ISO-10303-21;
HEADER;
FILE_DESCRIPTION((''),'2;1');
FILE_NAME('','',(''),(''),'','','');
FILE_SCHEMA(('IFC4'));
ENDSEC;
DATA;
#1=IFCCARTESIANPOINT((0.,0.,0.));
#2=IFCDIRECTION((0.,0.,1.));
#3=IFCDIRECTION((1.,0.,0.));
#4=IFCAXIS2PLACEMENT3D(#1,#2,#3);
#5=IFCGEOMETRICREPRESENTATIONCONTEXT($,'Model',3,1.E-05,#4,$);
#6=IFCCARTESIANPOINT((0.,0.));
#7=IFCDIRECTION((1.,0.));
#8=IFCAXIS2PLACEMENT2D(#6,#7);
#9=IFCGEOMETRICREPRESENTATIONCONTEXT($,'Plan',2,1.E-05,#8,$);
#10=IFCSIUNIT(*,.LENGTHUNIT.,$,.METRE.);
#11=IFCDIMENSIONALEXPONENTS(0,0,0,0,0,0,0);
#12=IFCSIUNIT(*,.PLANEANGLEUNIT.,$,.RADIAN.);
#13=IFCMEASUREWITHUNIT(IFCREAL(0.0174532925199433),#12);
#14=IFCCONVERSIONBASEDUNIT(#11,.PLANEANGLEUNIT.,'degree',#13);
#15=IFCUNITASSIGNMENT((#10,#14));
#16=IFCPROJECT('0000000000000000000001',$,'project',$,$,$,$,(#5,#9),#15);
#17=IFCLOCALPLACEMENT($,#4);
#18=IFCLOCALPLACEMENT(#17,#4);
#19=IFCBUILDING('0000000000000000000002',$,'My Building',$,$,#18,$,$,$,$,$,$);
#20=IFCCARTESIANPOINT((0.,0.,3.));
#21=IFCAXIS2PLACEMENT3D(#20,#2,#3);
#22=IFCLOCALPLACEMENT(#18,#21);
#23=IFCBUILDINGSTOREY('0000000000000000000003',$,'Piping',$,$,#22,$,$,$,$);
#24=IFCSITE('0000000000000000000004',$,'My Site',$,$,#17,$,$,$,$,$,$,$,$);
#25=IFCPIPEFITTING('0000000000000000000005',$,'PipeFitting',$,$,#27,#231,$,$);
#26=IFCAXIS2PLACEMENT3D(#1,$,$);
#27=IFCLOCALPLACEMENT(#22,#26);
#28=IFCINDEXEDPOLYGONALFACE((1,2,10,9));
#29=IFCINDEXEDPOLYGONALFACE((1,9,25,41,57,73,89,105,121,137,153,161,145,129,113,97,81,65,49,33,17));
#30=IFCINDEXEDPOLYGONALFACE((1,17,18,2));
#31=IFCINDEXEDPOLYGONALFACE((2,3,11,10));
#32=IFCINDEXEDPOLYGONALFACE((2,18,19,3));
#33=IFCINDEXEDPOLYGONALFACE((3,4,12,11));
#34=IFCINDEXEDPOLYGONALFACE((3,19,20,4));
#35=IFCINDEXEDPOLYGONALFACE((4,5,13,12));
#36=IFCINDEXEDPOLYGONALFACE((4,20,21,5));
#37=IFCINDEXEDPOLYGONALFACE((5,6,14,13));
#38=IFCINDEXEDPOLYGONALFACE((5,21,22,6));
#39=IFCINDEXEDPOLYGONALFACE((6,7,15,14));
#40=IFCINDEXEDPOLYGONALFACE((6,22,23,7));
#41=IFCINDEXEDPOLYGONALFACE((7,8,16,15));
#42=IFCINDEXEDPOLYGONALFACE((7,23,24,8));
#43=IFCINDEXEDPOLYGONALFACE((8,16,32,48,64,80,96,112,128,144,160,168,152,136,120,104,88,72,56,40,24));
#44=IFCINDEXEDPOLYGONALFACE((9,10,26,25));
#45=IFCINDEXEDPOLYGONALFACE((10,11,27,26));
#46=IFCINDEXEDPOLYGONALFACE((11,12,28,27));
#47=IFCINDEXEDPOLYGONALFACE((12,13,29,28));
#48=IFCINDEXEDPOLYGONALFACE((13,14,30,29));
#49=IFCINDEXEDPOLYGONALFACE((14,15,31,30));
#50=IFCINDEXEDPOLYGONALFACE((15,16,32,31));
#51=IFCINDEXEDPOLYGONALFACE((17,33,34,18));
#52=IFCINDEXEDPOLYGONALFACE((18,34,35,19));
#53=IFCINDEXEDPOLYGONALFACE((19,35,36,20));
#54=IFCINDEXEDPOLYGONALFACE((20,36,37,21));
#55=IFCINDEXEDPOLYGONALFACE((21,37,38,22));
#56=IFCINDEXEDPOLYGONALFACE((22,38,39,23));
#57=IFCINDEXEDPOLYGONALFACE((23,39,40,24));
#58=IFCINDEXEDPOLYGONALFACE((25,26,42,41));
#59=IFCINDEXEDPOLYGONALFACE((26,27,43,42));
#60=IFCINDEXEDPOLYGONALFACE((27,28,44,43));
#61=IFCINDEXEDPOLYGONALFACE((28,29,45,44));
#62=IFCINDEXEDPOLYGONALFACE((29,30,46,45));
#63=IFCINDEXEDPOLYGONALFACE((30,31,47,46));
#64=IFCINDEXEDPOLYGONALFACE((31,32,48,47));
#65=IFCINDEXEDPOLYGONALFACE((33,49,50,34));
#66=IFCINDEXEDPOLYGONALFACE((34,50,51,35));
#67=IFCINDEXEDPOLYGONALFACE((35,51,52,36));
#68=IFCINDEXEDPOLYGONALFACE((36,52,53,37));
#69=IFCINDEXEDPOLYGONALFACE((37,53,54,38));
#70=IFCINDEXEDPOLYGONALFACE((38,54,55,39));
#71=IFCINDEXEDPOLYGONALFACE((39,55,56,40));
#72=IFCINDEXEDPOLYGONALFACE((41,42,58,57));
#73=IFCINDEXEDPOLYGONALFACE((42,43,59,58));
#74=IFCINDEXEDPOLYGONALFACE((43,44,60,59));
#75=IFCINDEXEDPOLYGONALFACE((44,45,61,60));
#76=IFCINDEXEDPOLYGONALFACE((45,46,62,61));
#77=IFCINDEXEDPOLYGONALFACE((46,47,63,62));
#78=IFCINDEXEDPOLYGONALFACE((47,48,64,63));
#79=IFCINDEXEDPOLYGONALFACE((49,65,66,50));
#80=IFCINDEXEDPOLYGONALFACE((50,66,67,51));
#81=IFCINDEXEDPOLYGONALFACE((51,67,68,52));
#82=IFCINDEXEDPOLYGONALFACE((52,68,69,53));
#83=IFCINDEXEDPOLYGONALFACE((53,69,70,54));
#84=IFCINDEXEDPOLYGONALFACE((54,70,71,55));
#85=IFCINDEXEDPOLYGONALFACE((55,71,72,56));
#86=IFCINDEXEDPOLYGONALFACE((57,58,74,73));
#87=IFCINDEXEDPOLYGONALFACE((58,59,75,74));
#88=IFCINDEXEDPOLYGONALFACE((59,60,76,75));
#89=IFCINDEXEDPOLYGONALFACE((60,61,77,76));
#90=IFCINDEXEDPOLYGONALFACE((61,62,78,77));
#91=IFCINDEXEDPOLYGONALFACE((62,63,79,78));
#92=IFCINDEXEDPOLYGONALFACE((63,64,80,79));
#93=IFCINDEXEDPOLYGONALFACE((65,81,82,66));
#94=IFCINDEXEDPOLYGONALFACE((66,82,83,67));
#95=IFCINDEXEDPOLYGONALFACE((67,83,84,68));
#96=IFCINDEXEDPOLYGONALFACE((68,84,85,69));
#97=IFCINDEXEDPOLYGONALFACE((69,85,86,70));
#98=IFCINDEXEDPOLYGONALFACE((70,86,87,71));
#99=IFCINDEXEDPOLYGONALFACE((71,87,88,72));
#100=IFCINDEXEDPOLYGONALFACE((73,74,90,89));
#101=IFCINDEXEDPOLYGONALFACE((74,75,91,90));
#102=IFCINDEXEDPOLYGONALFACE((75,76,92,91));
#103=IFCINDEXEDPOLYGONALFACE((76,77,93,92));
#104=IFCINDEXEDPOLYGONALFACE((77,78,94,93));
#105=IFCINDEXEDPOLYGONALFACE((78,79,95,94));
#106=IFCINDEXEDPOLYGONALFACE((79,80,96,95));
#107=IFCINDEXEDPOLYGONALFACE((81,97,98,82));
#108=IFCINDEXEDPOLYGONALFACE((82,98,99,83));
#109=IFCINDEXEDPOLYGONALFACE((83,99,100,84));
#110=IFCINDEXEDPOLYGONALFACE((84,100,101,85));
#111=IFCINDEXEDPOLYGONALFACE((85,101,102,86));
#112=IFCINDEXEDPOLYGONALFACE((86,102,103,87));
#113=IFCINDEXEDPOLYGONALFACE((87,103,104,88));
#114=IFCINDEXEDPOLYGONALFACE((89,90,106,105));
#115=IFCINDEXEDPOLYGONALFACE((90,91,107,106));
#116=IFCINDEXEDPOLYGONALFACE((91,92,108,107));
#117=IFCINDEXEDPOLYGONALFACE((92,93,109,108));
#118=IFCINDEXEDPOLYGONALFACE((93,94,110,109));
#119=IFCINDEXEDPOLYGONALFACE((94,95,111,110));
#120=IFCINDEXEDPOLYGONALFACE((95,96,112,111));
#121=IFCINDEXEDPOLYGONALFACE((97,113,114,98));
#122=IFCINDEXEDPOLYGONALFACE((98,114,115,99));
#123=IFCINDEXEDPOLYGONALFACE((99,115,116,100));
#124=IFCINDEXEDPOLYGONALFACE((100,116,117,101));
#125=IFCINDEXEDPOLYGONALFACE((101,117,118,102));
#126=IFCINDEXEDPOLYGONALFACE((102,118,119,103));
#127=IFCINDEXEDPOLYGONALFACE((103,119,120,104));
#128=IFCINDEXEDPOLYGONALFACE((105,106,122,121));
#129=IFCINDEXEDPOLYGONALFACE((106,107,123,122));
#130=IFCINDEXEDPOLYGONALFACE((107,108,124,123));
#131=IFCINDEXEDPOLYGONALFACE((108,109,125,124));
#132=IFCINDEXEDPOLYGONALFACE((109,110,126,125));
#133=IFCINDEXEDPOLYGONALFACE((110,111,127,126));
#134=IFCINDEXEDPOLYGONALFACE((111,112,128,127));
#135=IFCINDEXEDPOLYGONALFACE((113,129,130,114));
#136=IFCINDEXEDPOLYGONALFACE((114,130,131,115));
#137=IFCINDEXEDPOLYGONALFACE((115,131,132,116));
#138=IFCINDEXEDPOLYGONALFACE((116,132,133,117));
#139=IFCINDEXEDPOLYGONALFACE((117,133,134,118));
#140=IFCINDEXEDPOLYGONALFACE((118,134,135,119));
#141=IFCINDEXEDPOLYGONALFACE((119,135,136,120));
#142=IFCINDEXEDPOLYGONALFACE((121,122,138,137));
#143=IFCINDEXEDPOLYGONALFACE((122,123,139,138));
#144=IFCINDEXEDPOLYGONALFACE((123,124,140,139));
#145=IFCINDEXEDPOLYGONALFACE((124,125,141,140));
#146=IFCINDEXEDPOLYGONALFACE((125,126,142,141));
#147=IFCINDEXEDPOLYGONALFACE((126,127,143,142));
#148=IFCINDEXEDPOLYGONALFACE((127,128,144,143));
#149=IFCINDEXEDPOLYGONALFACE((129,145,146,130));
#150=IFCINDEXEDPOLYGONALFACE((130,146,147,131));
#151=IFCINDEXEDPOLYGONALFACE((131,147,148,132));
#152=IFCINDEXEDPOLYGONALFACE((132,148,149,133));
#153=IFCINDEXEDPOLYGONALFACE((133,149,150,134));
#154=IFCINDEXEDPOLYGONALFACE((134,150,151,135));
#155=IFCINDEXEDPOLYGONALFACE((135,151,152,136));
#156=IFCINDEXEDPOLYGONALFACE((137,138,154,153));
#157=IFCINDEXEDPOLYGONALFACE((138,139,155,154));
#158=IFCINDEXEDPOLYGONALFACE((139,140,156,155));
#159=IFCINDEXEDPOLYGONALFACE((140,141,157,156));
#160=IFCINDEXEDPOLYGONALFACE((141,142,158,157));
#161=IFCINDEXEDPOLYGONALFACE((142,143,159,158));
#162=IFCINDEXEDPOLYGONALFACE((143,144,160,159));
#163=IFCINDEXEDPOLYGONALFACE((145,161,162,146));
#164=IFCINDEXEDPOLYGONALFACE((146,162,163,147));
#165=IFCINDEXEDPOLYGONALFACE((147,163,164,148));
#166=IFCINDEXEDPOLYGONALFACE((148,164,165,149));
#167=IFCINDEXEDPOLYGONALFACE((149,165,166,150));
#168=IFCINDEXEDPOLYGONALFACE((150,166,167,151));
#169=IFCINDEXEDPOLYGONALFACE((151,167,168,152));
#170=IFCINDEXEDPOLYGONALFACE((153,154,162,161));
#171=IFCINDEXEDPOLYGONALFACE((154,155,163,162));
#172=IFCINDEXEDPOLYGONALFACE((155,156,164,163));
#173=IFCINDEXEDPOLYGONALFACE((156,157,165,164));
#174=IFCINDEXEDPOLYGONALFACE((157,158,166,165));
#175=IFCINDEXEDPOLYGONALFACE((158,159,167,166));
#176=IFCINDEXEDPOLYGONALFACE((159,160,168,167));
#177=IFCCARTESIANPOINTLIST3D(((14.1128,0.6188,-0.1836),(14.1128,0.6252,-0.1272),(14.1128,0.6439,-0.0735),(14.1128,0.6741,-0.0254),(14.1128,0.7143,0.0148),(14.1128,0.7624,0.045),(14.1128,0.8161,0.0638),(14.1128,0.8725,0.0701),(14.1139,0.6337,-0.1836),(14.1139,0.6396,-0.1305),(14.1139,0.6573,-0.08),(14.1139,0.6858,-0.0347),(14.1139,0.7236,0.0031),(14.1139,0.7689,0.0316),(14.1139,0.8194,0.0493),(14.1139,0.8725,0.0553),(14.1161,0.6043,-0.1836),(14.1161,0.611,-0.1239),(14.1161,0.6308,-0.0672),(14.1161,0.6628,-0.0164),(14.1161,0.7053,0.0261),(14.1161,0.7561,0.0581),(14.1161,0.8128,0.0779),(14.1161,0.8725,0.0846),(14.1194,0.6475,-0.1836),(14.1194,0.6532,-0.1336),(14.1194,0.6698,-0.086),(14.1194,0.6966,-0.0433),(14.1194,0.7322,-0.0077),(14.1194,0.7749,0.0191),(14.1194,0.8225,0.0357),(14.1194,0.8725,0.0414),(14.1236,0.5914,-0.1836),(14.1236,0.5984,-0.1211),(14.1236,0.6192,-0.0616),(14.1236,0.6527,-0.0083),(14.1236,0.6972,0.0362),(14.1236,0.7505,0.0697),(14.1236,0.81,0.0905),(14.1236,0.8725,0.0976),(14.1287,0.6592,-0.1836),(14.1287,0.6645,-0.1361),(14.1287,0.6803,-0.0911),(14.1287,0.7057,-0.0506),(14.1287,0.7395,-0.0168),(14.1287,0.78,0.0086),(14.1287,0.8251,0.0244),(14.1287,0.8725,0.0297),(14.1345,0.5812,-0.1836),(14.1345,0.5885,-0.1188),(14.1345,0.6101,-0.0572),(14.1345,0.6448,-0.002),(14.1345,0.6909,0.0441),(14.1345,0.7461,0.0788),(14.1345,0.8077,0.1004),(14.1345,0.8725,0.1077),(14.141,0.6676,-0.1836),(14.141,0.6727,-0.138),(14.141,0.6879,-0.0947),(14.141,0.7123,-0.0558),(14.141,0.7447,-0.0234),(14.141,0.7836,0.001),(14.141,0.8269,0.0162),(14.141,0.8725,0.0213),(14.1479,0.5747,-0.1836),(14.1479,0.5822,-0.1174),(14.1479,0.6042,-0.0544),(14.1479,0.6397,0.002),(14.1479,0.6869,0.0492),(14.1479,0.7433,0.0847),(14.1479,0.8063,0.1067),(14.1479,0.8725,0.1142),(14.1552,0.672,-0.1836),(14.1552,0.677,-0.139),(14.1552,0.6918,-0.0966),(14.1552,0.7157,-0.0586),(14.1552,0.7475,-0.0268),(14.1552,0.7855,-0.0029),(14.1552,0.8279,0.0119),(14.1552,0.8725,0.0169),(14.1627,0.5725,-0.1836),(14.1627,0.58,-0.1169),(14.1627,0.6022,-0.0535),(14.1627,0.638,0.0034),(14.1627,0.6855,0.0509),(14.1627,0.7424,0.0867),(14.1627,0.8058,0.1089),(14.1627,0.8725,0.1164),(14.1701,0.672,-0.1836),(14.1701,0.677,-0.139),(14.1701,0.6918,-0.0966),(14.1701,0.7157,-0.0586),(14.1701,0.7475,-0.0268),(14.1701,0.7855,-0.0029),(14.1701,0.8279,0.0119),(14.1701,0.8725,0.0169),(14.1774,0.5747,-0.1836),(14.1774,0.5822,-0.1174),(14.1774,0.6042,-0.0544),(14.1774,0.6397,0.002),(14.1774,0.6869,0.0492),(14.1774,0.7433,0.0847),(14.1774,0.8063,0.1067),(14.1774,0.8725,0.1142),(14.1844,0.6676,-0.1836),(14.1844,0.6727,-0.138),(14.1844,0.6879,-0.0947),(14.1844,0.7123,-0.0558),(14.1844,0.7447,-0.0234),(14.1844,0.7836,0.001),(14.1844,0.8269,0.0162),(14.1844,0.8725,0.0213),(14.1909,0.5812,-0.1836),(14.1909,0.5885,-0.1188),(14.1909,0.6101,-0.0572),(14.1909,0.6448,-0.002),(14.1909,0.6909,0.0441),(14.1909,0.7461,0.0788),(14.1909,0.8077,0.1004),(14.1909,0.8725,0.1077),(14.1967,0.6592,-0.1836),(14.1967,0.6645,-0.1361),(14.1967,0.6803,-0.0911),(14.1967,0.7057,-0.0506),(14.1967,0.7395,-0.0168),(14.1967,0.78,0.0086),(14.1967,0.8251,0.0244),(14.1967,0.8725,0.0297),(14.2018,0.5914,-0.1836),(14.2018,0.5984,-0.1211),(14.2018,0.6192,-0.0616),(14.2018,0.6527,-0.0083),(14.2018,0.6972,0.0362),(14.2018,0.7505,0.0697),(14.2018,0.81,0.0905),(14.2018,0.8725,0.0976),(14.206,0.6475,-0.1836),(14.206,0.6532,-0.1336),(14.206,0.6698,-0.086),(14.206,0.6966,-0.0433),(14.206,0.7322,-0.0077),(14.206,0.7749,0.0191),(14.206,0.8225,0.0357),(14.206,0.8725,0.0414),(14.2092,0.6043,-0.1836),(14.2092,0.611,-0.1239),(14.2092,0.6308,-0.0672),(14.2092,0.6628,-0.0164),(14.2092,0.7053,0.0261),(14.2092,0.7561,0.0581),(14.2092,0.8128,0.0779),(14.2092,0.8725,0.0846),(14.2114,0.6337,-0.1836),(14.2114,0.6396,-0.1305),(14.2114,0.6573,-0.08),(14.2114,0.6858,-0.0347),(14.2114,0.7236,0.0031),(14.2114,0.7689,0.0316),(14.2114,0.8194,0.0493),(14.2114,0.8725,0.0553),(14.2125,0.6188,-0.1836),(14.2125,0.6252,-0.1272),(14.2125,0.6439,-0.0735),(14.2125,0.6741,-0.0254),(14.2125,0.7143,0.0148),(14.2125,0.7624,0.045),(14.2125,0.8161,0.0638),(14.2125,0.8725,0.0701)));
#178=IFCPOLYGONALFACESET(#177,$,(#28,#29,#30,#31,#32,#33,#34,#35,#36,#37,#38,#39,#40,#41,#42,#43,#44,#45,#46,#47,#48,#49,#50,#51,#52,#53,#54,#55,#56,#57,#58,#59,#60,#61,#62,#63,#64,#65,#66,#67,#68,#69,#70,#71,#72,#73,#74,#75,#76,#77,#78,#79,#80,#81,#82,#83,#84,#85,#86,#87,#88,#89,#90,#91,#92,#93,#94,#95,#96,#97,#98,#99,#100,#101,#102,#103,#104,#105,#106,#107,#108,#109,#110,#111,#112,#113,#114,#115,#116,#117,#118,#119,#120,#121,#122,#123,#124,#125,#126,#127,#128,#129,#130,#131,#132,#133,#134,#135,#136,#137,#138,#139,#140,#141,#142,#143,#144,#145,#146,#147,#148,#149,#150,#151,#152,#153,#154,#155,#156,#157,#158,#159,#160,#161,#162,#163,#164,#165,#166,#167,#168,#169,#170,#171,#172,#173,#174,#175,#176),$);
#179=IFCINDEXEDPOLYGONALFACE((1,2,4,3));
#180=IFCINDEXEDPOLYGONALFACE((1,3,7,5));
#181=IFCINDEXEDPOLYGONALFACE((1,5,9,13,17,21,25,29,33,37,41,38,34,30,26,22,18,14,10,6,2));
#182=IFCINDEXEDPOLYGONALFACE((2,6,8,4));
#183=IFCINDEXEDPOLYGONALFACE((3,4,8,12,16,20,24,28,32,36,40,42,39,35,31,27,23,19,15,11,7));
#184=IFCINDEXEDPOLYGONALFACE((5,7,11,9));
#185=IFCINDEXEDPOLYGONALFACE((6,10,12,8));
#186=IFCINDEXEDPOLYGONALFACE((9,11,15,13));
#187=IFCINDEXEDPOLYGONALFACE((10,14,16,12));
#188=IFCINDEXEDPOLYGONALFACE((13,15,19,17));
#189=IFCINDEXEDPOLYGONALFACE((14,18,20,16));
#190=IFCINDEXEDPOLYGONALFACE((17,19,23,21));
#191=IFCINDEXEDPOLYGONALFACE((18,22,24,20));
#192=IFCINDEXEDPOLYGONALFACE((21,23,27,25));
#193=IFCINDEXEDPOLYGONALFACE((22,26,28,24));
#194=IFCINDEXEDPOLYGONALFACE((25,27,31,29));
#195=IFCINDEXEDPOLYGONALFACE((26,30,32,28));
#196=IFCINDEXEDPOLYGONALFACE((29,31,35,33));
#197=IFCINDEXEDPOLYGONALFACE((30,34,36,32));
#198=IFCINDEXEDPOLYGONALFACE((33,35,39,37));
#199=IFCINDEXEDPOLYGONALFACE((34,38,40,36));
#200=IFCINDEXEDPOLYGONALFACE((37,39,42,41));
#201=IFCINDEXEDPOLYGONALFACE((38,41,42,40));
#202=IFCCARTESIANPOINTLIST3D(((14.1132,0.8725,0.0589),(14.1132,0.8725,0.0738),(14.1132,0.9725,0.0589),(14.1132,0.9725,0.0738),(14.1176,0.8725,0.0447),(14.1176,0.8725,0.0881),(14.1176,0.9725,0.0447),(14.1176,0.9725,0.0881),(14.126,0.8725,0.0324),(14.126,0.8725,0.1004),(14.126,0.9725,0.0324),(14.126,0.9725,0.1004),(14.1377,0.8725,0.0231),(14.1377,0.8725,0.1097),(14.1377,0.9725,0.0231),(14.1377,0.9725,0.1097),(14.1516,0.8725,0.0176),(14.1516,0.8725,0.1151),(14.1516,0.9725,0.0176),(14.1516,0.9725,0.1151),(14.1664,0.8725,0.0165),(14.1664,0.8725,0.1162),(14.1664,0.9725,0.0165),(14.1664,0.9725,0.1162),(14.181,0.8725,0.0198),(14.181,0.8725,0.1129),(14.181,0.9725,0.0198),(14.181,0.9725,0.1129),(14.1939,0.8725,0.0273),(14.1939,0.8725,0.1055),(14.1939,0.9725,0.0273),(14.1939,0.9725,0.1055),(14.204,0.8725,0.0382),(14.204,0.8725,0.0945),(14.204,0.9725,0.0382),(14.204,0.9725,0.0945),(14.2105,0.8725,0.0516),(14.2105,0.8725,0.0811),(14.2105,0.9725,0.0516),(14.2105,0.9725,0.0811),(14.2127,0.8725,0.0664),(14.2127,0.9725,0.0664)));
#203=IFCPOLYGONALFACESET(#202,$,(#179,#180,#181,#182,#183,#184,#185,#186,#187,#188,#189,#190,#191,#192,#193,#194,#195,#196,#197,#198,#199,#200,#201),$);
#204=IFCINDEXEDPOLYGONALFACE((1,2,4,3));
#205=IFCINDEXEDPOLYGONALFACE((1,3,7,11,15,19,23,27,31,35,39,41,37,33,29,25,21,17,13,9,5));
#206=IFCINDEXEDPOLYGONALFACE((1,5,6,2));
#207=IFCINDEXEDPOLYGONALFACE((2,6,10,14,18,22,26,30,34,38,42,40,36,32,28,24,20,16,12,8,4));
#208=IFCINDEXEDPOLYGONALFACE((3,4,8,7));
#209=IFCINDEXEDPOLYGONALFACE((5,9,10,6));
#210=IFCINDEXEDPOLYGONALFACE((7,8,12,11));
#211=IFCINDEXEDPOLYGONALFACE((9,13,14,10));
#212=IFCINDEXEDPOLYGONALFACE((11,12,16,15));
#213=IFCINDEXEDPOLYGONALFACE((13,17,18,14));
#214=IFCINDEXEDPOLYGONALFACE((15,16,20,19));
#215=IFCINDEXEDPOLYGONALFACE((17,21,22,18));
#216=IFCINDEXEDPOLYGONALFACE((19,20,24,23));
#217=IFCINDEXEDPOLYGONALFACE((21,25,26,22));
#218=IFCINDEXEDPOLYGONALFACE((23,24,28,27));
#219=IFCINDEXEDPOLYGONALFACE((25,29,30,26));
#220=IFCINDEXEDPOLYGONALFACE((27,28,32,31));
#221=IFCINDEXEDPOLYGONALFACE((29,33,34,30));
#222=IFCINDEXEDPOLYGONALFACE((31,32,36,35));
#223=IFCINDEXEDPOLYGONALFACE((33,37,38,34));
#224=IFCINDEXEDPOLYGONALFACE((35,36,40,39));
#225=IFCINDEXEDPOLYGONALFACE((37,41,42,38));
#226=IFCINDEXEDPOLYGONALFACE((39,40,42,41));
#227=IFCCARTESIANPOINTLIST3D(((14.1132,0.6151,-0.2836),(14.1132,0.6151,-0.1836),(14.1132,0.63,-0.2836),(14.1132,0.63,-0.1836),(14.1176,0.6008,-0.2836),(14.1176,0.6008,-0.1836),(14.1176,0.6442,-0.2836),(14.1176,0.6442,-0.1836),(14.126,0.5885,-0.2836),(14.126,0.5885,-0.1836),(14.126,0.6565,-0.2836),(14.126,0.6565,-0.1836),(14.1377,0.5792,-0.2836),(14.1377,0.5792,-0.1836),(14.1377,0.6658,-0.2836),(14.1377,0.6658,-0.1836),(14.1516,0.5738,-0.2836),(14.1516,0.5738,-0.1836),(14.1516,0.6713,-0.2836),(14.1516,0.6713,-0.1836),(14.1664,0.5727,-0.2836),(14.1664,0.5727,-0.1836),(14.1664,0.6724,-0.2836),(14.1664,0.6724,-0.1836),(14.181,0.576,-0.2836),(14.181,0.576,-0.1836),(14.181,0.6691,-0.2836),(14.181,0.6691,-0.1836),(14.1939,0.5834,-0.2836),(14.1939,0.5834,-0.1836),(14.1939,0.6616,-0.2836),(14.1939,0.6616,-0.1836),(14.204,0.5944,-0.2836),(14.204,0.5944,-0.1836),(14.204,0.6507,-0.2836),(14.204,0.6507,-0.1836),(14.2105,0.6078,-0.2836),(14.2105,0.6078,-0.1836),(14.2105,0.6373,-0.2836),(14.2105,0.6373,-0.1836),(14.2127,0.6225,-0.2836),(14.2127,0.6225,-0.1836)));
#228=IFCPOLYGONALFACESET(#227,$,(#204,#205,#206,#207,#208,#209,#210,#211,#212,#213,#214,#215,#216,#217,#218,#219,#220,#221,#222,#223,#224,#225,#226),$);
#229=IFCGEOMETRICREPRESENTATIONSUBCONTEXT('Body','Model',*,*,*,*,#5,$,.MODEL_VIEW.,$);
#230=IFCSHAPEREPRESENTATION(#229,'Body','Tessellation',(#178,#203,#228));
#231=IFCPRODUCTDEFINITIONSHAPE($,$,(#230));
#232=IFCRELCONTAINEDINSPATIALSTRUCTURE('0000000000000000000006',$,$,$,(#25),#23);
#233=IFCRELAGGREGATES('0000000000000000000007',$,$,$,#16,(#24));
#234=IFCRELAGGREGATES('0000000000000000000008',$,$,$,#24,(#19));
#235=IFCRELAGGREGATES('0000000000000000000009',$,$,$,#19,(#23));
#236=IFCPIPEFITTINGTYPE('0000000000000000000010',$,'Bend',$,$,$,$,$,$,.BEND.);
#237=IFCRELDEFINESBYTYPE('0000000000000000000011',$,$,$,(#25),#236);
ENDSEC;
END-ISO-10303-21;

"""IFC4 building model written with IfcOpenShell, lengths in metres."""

from ifc_helpers import new_model, entity, si_unit, converted_unit, frame, origin_with_axes, origin_2d_with_axis, place, context, subcontext, project, spatial, circle, extrude, source, transform, mapped, type_object, type_shapes, element, save


model = new_model("IFC4")

# Units and contexts
model_context = context("Model", 3, precision=1e-05, world=origin_with_axes())
plan_context = context("Plan", 2, precision=1e-05, world=origin_2d_with_axis())
body_context = subcontext(model_context, "Body", "Model", "MODEL_VIEW")
ifc_project = project(units=[si_unit("LENGTHUNIT", "METRE"), converted_unit("PLANEANGLEUNIT", "degree", entity("IfcReal", 0.0174532925199433), si_unit("PLANEANGLEUNIT", "RADIAN"), dimensions=[0, 0, 0, 0, 0, 0, 0])], contexts=[model_context, plan_context])

# Site, building, storey
site_placement = place(None, origin_with_axes())
site = spatial("IfcSite", under=ifc_project, at=site_placement, Name="My Site")
building_placement = place(site_placement, origin_with_axes())
building = spatial("IfcBuilding", under=site, at=building_placement, Name="My Building")
storey_placement = place(building_placement, frame((0.0, 0.0, 3.0), z_axis=(0.0, 0.0, 1.0), x_axis=(1.0, 0.0, 0.0)))
storey = spatial("IfcBuildingStorey", under=building, at=storey_placement, Name="Piping")

# Pipe fitting
pipe_fitting_type_1 = type_object("IfcPipeFittingType", Name="Bend", PredefinedType="BEND")
shared_shape = source(origin_with_axes(), body_context, "Body", "SolidModel", [
    entity("IfcSweptDiskSolid", entity("IfcIndexedPolyCurve", entity("IfcCartesianPointList3D", [[0.0, 0.0, 0.1], [0.0, -0.0732, 0.2768], [0.0, -0.25, 0.35]]), [entity("IfcArcIndex", [1, 2, 3])]), 0.05),
    extrude(circle(Radius=0.05), origin_with_axes(), (0.0, 0.0, 1.0), 0.1),
    extrude(circle(Radius=0.05), frame((0.0, -0.25, 0.35), z_axis=(0.0, -1.0, -0.000002), x_axis=(1.0, 0.0, 0.0)), (0.0, 0.0, 1.0), 0.1),
])
type_shapes(pipe_fitting_type_1, [shared_shape])
for number, where, z_axis, x_axis, name in (
    (1, (14.1627, 0.9725, 0.0664), (0.0, -1.0, 0.000002), (1.0, 0.0, 0.0), "PipeFitting"),
):
    element("IfcPipeFitting", number, at=place(storey_placement, frame(where, z_axis=z_axis, x_axis=x_axis)), inside=storey, type_object=pipe_fitting_type_1, Name=name, context=body_context, shape_type="MappedRepresentation", body=[
        mapped(shared_shape, transform((0.0, 0.0, 0.0), x_axis=(1.0, 0.0, 0.0), y_axis=(0.0, 1.0, 0.0), z_axis=(0.0, 0.0, 1.0), scale=1.0)),
    ])

save(model, "model.ifc")
